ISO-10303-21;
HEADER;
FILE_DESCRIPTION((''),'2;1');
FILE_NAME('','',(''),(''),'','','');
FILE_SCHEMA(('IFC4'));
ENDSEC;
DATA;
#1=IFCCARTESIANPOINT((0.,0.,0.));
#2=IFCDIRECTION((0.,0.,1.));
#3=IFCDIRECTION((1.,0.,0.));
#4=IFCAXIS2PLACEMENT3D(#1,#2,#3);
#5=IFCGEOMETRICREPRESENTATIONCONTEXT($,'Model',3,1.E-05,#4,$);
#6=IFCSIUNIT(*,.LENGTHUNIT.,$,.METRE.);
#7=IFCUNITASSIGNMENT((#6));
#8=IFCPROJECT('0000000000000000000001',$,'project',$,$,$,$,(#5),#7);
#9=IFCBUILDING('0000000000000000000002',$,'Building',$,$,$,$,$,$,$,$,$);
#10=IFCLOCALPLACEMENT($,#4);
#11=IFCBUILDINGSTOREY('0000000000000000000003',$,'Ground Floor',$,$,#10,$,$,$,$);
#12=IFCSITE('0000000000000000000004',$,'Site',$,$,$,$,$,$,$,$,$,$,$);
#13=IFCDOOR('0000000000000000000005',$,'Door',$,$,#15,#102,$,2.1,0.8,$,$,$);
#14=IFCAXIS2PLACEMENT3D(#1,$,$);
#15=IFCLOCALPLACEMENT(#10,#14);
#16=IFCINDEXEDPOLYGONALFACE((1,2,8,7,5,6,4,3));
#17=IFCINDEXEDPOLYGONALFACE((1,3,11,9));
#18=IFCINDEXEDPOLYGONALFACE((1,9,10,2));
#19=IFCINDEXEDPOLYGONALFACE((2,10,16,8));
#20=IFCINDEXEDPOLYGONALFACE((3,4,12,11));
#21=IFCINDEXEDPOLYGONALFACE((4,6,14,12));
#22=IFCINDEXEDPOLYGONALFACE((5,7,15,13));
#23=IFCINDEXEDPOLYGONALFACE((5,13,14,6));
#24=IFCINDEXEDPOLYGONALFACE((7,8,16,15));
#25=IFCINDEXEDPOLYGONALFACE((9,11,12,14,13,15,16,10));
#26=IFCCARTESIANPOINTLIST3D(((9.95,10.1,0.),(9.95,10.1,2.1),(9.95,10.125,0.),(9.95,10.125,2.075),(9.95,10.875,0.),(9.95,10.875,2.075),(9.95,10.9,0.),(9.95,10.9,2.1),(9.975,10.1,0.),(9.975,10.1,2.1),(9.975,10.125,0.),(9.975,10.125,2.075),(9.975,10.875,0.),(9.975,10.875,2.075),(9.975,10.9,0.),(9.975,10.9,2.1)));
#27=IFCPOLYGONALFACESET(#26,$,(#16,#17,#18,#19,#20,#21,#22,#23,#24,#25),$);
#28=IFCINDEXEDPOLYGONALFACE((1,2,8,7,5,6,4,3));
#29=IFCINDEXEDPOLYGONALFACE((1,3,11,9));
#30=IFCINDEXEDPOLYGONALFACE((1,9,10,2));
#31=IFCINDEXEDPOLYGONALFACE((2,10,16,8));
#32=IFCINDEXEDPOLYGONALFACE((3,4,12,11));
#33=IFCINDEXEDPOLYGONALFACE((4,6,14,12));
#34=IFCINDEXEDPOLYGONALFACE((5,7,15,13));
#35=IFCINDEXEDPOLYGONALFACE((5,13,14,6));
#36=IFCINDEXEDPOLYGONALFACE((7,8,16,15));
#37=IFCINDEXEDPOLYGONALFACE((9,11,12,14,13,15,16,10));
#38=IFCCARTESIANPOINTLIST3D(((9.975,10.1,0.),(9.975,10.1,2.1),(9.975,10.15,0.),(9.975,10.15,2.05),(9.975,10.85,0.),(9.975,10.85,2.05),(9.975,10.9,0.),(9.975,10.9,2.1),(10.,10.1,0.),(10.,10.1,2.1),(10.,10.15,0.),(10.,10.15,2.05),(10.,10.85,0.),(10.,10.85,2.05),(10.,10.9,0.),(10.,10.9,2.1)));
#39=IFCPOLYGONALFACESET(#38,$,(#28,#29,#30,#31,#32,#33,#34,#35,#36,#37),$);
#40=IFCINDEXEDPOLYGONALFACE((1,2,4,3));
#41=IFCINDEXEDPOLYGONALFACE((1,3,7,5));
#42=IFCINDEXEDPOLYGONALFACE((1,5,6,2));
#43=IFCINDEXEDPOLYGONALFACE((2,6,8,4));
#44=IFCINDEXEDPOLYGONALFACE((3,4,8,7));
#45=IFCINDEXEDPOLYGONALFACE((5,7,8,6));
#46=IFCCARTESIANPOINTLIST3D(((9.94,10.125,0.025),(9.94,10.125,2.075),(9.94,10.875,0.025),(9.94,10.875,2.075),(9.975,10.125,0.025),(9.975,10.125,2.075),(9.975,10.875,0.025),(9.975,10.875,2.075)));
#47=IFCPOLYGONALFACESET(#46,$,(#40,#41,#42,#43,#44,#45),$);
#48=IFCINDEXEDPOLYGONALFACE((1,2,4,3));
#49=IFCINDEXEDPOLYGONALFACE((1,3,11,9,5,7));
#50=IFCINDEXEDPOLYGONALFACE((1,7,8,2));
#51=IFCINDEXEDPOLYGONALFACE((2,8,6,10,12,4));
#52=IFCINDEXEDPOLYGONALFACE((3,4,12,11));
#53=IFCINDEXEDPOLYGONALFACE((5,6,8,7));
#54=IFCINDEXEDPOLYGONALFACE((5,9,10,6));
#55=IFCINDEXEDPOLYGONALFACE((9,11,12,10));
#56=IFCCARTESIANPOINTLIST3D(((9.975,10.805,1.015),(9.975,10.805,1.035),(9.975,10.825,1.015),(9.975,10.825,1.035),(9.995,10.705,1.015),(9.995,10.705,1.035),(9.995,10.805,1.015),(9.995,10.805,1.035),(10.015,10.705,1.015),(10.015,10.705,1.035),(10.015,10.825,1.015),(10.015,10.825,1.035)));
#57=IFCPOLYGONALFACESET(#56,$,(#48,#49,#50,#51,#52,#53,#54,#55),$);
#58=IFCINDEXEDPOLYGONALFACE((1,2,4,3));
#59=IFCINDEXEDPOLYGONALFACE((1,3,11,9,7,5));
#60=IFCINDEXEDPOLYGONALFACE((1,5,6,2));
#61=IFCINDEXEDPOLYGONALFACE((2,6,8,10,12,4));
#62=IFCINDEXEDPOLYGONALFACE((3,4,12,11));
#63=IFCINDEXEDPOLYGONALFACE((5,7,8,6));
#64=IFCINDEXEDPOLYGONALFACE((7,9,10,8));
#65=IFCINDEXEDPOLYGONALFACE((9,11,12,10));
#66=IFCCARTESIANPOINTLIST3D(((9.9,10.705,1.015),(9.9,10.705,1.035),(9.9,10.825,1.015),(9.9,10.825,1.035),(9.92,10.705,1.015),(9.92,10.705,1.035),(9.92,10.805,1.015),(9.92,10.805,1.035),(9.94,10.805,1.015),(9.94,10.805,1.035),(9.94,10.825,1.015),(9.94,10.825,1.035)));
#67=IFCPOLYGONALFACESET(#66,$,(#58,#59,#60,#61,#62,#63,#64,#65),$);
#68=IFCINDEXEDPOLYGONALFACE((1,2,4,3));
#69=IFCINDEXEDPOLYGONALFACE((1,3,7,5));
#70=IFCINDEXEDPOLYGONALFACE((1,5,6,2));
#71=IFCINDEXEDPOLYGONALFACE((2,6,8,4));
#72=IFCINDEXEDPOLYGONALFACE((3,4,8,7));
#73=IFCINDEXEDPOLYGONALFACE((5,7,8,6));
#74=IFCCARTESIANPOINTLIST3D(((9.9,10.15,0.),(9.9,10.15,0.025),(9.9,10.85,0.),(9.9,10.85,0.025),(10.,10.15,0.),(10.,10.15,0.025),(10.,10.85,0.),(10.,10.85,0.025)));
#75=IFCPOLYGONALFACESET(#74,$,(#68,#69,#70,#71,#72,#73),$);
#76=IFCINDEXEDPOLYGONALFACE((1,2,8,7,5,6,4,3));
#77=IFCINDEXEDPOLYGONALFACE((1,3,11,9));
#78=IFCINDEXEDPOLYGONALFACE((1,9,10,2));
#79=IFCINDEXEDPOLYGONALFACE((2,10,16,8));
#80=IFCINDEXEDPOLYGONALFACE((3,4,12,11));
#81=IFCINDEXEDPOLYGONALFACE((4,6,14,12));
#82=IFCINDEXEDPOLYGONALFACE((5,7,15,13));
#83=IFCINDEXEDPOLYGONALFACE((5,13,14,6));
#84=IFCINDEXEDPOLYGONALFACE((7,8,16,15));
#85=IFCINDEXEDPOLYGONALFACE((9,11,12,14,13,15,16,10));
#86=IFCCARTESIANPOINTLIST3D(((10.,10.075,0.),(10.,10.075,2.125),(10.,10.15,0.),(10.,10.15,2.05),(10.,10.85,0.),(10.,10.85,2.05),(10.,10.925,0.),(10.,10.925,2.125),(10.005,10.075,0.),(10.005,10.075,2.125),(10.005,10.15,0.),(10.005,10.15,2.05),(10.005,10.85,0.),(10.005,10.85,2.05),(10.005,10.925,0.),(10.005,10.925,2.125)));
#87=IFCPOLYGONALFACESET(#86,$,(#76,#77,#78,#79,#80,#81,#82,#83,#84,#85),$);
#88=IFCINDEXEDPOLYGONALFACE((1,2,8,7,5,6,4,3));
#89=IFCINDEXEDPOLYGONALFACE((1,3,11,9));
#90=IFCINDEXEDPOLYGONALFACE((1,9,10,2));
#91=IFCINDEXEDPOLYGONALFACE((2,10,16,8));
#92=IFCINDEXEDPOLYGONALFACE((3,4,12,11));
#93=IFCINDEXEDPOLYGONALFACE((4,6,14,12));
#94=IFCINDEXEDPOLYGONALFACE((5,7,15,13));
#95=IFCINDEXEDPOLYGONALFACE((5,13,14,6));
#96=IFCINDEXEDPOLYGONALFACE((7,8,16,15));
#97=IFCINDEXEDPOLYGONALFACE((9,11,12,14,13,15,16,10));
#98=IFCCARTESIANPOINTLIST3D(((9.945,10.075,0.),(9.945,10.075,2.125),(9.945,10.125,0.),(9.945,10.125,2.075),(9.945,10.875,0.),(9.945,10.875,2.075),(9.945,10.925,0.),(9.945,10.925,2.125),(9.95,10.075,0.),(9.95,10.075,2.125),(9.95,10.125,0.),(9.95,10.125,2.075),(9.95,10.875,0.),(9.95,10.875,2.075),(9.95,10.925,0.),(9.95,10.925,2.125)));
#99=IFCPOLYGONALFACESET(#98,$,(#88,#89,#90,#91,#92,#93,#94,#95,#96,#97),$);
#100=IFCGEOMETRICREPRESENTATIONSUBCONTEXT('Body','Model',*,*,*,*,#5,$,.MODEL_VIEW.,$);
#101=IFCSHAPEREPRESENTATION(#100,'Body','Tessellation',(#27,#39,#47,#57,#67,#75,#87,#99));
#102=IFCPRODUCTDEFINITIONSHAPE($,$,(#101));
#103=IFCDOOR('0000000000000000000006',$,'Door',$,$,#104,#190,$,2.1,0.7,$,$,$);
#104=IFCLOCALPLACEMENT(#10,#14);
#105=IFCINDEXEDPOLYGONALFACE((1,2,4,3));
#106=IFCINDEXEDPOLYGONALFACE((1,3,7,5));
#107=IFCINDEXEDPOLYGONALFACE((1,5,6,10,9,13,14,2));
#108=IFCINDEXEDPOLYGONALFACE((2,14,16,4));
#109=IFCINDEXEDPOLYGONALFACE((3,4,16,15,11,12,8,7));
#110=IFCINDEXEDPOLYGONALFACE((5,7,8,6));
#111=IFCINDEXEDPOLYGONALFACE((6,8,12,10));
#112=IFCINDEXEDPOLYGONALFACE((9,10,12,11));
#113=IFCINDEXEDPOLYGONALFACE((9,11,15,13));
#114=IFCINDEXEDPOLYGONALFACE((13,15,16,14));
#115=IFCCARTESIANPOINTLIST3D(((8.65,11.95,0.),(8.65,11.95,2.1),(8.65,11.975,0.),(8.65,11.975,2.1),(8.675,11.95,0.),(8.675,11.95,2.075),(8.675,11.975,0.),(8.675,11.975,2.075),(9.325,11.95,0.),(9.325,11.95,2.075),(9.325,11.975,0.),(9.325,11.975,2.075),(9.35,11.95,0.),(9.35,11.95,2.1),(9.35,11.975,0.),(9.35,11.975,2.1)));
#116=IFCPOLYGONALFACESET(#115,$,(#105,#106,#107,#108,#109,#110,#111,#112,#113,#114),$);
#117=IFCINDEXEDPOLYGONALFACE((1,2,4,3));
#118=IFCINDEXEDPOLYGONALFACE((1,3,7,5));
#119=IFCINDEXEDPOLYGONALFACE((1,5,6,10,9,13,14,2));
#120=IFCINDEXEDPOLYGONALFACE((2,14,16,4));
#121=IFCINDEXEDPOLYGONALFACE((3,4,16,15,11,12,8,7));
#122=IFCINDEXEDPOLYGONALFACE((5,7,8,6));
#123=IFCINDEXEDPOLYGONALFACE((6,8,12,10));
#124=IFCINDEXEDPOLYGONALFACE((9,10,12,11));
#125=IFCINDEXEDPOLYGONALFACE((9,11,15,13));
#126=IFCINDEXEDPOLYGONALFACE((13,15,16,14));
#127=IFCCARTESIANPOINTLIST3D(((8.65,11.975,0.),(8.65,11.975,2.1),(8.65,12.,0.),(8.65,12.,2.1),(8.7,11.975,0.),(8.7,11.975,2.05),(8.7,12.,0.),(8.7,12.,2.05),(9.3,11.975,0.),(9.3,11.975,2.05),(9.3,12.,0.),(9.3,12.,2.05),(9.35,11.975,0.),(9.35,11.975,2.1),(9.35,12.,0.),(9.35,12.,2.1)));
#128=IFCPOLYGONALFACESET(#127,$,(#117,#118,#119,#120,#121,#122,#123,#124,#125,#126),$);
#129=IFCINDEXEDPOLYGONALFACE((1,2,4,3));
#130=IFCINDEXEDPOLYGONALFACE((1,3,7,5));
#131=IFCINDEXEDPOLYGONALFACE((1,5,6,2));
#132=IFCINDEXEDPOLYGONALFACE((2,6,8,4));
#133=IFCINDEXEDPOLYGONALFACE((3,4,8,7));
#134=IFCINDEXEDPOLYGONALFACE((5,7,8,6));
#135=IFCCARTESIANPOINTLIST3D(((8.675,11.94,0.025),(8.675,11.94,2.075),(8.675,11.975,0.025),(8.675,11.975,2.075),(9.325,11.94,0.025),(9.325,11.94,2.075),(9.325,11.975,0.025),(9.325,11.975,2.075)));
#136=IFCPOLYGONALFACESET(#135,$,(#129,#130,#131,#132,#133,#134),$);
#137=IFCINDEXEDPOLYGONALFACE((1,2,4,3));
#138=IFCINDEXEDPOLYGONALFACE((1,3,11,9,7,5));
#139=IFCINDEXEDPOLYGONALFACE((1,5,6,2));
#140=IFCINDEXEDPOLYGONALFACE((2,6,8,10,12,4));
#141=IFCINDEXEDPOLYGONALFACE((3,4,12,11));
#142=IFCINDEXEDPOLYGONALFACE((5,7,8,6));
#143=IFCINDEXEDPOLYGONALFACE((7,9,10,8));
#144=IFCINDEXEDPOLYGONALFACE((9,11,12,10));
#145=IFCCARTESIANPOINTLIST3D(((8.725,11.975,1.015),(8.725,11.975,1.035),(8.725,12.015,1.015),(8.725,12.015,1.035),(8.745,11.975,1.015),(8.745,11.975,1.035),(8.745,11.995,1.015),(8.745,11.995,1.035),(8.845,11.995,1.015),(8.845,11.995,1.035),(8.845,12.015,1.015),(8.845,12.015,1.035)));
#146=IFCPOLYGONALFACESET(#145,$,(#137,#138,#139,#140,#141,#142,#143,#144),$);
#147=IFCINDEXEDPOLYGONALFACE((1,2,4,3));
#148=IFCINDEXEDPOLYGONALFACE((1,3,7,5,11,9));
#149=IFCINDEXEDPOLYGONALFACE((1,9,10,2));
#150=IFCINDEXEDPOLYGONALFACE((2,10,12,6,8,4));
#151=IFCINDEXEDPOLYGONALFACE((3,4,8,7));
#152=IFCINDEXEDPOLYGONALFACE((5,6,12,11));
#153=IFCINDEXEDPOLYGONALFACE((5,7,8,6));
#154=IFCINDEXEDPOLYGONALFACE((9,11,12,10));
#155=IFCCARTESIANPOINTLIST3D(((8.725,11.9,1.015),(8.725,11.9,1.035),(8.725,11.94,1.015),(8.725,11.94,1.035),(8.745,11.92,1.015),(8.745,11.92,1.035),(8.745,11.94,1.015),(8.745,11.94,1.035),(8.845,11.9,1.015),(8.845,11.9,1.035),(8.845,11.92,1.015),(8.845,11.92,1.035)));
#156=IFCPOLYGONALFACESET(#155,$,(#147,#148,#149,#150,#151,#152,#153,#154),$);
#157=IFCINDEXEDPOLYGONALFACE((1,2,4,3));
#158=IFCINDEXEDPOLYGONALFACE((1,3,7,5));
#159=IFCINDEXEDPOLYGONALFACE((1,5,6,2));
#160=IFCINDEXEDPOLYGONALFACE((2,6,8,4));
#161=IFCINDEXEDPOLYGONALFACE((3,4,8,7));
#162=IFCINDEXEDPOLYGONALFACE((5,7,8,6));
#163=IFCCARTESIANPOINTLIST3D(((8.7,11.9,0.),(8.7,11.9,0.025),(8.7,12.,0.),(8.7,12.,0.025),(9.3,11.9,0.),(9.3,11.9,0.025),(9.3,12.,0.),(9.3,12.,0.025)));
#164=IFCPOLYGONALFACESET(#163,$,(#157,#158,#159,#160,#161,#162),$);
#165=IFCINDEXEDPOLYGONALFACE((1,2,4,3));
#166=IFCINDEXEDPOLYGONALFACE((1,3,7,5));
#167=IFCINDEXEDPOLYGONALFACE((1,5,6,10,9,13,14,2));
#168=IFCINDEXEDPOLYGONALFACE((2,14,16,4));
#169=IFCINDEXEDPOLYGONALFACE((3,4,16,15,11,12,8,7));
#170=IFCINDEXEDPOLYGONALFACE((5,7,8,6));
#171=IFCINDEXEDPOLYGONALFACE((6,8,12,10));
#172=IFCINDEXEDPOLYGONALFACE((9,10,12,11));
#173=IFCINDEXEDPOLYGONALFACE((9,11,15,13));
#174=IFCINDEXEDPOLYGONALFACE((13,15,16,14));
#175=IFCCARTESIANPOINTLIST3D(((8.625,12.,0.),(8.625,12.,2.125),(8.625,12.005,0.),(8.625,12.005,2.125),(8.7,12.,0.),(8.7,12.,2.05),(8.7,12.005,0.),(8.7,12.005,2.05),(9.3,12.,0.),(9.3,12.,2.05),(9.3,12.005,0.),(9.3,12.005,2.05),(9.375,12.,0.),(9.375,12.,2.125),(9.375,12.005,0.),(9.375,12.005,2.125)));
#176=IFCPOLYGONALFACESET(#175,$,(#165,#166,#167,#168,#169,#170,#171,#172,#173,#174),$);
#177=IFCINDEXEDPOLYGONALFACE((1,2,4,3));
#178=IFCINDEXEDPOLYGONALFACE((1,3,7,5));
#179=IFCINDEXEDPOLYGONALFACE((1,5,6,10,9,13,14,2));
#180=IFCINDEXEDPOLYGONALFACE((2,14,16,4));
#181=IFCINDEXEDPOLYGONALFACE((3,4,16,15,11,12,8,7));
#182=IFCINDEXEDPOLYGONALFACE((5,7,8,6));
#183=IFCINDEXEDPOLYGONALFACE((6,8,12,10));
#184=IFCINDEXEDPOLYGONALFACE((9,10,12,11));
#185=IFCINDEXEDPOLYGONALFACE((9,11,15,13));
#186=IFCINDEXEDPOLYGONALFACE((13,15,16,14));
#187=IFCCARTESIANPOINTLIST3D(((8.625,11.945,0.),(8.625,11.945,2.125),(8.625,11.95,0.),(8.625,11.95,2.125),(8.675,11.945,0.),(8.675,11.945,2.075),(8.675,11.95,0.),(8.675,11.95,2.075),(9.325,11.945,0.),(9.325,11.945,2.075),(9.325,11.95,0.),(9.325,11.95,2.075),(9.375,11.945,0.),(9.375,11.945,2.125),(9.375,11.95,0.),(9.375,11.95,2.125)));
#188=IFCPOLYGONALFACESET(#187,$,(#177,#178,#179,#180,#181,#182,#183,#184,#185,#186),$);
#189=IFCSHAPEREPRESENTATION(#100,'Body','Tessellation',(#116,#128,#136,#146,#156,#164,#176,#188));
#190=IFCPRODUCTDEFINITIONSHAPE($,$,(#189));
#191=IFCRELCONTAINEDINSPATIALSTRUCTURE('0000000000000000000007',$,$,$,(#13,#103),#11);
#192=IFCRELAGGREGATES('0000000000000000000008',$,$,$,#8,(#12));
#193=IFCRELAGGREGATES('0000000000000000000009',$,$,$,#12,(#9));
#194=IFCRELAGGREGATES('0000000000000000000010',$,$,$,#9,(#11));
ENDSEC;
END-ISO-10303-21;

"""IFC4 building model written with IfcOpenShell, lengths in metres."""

from ifc_helpers import new_model, si_unit, frame, origin_with_axes, place, context, subcontext, project, spatial, line, indexed_curve, outline, extrude, element, save


model = new_model("IFC4")

# Units and contexts
model_context = context("Model", 3, precision=1e-05, world=origin_with_axes())
body_context = subcontext(model_context, "Body", "Model", "MODEL_VIEW")
ifc_project = project(units=[si_unit("LENGTHUNIT", "METRE")], contexts=[model_context])

# Site, building, storey
site = spatial("IfcSite", under=ifc_project, Name="Site")
building = spatial("IfcBuilding", under=site, Name="Building")
storey_placement = place(None, origin_with_axes())
storey = spatial("IfcBuildingStorey", under=building, at=storey_placement, Name="Ground Floor")

# Doors
door_1_placement = place(storey_placement, frame((10.0, 10.1, 0.0), z_axis=(0.0, 0.0, 1.0), x_axis=(0.0, 1.0, 0.0)))
element("IfcDoor", 1, at=door_1_placement, inside=storey, Name="Door", OverallHeight=2.1, OverallWidth=0.8, context=body_context, shape_type="SweptSolid", body=[
    extrude(outline(indexed_curve([(0.0, 0.0), (0.0, 2.1), (0.8, 2.1), (0.8, 0.0), (0.775, 0.0), (0.775, 2.075), (0.025, 2.075), (0.025, 0.0)], segments=[line(1, 2, 3, 4, 5, 6, 7, 8, 1)])), frame((0.0, 0.025, 0.0), z_axis=(0.0, -1.0, 0.0), x_axis=(1.0, 0.0, 0.0)), (0.0, 0.0, -1.0), 0.025),
    extrude(outline(indexed_curve([(0.0, 0.0), (0.0, 2.1), (0.8, 2.1), (0.8, 0.0), (0.75, 0.0), (0.75, 2.05), (0.05, 2.05), (0.05, 0.0)], segments=[line(1, 2, 3, 4, 5, 6, 7, 8, 1)])), frame((0.0, 0.0, 0.0), z_axis=(0.0, -1.0, 0.0), x_axis=(1.0, 0.0, 0.0)), (0.0, 0.0, -1.0), 0.025),
    extrude(outline(indexed_curve([(0.0, 0.0), (0.75, 0.0), (0.75, 0.035), (0.0, 0.035)], segments=[line(1, 2, 3, 4, 1)])), frame((0.025, 0.025, 0.025), z_axis=(0.0, 0.0, 1.0), x_axis=(1.0, 0.0, 0.0)), (0.0, 0.0, 1.0), 2.05),
    extrude(outline(indexed_curve([(0.0, 0.0), (0.0, -0.04), (-0.12, -0.04), (-0.12, -0.02), (-0.02, -0.02), (-0.02, 0.0)], segments=[line(1, 2, 3, 4, 5, 6, 1)])), frame((0.725, 0.025, 1.015), z_axis=(0.0, 0.0, 1.0), x_axis=(1.0, 0.0, 0.0)), (0.0, 0.0, 1.0), 0.02),
    extrude(outline(indexed_curve([(0.0, 0.0), (0.0, 0.04), (-0.12, 0.04), (-0.12, 0.02), (-0.02, 0.02), (-0.02, 0.0)], segments=[line(1, 2, 3, 4, 5, 6, 1)])), frame((0.725, 0.06, 1.015), z_axis=(0.0, 0.0, 1.0), x_axis=(1.0, 0.0, 0.0)), (0.0, 0.0, 1.0), 0.02),
    extrude(outline(indexed_curve([(0.0, 0.0), (0.7, 0.0), (0.7, 0.1), (0.0, 0.1)], segments=[line(1, 2, 3, 4, 1)])), frame((0.05, 0.0, 0.0), z_axis=(0.0, 0.0, 1.0), x_axis=(1.0, 0.0, 0.0)), (0.0, 0.0, 1.0), 0.025),
    extrude(outline(indexed_curve([(0.0, 0.0), (0.0, 2.125), (0.85, 2.125), (0.85, 0.0), (0.775, 0.0), (0.775, 2.05), (0.075, 2.05), (0.075, 0.0)], segments=[line(1, 2, 3, 4, 5, 6, 7, 8, 1)])), frame((-0.025, -0.005, 0.0), z_axis=(0.0, -1.0, 0.0), x_axis=(1.0, 0.0, 0.0)), (0.0, 0.0, -1.0), 0.005),
    extrude(outline(indexed_curve([(0.0, 0.0), (0.0, 2.125), (0.85, 2.125), (0.85, 0.0), (0.8, 0.0), (0.8, 2.075), (0.05, 2.075), (0.05, 0.0)], segments=[line(1, 2, 3, 4, 5, 6, 7, 8, 1)])), frame((-0.025, 0.05, 0.0), z_axis=(0.0, -1.0, 0.0), x_axis=(1.0, 0.0, 0.0)), (0.0, 0.0, -1.0), 0.005),
])
door_2_placement = place(storey_placement, frame((9.35, 12.0, 0.0), z_axis=(0.0, 0.0, 1.0), x_axis=(-1.0, 0.0, 0.0)))
element("IfcDoor", 2, at=door_2_placement, inside=storey, Name="Door", OverallHeight=2.1, OverallWidth=0.7, context=body_context, shape_type="SweptSolid", body=[
    extrude(outline(indexed_curve([(0.0, 0.0), (0.0, 2.1), (0.7, 2.1), (0.7, 0.0), (0.675, 0.0), (0.675, 2.075), (0.025, 2.075), (0.025, 0.0)], segments=[line(1, 2, 3, 4, 5, 6, 7, 8, 1)])), frame((0.0, 0.025, 0.0), z_axis=(0.0, -1.0, 0.0), x_axis=(1.0, 0.0, 0.0)), (0.0, 0.0, -1.0), 0.025),
    extrude(outline(indexed_curve([(0.0, 0.0), (0.0, 2.1), (0.7, 2.1), (0.7, 0.0), (0.65, 0.0), (0.65, 2.05), (0.05, 2.05), (0.05, 0.0)], segments=[line(1, 2, 3, 4, 5, 6, 7, 8, 1)])), frame((0.0, 0.0, 0.0), z_axis=(0.0, -1.0, 0.0), x_axis=(1.0, 0.0, 0.0)), (0.0, 0.0, -1.0), 0.025),
    extrude(outline(indexed_curve([(0.0, 0.0), (0.65, 0.0), (0.65, 0.035), (0.0, 0.035)], segments=[line(1, 2, 3, 4, 1)])), frame((0.025, 0.025, 0.025), z_axis=(0.0, 0.0, 1.0), x_axis=(1.0, 0.0, 0.0)), (0.0, 0.0, 1.0), 2.05),
    extrude(outline(indexed_curve([(0.0, 0.0), (0.0, -0.04), (-0.12, -0.04), (-0.12, -0.02), (-0.02, -0.02), (-0.02, 0.0)], segments=[line(1, 2, 3, 4, 5, 6, 1)])), frame((0.625, 0.025, 1.015), z_axis=(0.0, 0.0, 1.0), x_axis=(1.0, 0.0, 0.0)), (0.0, 0.0, 1.0), 0.02),
    extrude(outline(indexed_curve([(0.0, 0.0), (0.0, 0.04), (-0.12, 0.04), (-0.12, 0.02), (-0.02, 0.02), (-0.02, 0.0)], segments=[line(1, 2, 3, 4, 5, 6, 1)])), frame((0.625, 0.06, 1.015), z_axis=(0.0, 0.0, 1.0), x_axis=(1.0, 0.0, 0.0)), (0.0, 0.0, 1.0), 0.02),
    extrude(outline(indexed_curve([(0.0, 0.0), (0.6, 0.0), (0.6, 0.1), (0.0, 0.1)], segments=[line(1, 2, 3, 4, 1)])), frame((0.05, 0.0, 0.0), z_axis=(0.0, 0.0, 1.0), x_axis=(1.0, 0.0, 0.0)), (0.0, 0.0, 1.0), 0.025),
    extrude(outline(indexed_curve([(0.0, 0.0), (0.0, 2.125), (0.75, 2.125), (0.75, 0.0), (0.675, 0.0), (0.675, 2.05), (0.075, 2.05), (0.075, 0.0)], segments=[line(1, 2, 3, 4, 5, 6, 7, 8, 1)])), frame((-0.025, -0.005, 0.0), z_axis=(0.0, -1.0, 0.0), x_axis=(1.0, 0.0, 0.0)), (0.0, 0.0, -1.0), 0.005),
    extrude(outline(indexed_curve([(0.0, 0.0), (0.0, 2.125), (0.75, 2.125), (0.75, 0.0), (0.7, 0.0), (0.7, 2.075), (0.05, 2.075), (0.05, 0.0)], segments=[line(1, 2, 3, 4, 5, 6, 7, 8, 1)])), frame((-0.025, 0.05, 0.0), z_axis=(0.0, -1.0, 0.0), x_axis=(1.0, 0.0, 0.0)), (0.0, 0.0, -1.0), 0.005),
])

save(model, "model.ifc")
